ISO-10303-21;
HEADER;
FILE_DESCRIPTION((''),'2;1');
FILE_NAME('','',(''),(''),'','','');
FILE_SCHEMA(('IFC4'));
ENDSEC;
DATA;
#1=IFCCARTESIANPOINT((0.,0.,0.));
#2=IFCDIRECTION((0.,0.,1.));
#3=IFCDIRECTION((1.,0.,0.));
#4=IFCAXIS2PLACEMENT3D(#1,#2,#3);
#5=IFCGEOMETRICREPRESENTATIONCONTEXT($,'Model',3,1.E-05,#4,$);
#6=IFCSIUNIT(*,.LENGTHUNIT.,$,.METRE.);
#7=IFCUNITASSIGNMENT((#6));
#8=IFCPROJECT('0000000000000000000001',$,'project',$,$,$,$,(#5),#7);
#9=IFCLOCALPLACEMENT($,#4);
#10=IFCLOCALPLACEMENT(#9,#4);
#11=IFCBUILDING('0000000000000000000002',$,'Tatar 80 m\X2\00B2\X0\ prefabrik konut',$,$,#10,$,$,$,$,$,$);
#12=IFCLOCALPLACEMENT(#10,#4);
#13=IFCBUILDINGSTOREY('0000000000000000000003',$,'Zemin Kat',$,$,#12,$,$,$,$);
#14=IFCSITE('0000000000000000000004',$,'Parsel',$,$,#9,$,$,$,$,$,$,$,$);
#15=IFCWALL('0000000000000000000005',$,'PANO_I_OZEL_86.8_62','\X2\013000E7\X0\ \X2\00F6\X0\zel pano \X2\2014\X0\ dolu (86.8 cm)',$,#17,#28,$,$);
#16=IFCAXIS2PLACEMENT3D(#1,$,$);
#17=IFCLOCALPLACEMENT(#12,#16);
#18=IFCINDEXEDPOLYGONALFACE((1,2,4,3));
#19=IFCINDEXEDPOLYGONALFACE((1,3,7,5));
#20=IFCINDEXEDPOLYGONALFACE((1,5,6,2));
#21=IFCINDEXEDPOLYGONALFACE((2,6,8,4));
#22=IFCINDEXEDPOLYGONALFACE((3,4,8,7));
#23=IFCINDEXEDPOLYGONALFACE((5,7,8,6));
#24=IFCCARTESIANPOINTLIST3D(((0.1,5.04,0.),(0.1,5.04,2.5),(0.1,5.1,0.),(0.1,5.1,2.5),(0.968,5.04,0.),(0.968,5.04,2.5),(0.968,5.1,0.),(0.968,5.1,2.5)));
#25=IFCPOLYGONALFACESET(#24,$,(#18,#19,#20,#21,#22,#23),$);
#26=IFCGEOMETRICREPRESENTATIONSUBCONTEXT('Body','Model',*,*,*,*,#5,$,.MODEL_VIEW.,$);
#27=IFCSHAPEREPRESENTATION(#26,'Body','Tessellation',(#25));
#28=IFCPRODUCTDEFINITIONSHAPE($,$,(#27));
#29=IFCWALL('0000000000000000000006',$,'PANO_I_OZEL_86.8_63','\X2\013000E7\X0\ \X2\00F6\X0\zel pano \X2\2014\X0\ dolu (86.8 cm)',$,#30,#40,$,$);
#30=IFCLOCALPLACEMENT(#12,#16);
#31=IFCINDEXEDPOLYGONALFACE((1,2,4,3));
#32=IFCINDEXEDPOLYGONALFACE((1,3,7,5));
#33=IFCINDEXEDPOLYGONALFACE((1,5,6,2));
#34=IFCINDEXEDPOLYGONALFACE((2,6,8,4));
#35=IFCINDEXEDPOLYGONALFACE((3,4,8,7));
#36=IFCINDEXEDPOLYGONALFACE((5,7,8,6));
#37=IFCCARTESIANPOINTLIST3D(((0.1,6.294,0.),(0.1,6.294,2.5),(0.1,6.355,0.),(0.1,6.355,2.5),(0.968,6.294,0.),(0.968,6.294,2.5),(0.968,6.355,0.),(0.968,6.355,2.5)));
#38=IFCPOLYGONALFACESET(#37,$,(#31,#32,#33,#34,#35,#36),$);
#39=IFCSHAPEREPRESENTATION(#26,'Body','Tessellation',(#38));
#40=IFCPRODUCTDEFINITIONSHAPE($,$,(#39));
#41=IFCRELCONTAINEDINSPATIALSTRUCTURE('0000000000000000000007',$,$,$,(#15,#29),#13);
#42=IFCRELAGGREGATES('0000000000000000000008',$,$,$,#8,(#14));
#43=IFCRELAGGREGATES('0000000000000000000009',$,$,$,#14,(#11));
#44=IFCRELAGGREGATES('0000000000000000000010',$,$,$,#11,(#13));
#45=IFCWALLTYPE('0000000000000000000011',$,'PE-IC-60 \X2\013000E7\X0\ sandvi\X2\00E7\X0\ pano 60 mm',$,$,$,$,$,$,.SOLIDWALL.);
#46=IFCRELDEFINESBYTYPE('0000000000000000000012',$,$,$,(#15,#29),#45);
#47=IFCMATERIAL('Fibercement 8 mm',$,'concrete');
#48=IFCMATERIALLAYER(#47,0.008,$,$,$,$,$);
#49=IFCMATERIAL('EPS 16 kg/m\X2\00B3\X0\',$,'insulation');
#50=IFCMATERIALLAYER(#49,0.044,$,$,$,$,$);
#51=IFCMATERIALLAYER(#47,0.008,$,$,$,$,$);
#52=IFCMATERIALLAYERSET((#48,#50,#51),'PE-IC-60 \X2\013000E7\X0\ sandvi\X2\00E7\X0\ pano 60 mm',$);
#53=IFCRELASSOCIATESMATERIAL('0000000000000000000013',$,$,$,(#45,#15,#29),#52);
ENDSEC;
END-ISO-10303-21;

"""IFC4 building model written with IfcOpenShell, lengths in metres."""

from ifc_helpers import new_model, si_unit, frame, origin_with_axes, place, context, subcontext, project, spatial, line, indexed_curve, outline, extrude, material, layer, layer_set, layer_usage, type_object, element, save


model = new_model("IFC4")

# Units and contexts
model_context = context("Model", 3, precision=1e-05, world=origin_with_axes())
body_context = subcontext(model_context, "Body", "Model", "MODEL_VIEW")
ifc_project = project(units=[si_unit("LENGTHUNIT", "METRE")], contexts=[model_context])

# Site, building, storey
site_placement = place(None, origin_with_axes())
site = spatial("IfcSite", under=ifc_project, at=site_placement, Name="Parsel")
building_placement = place(site_placement, origin_with_axes())
building = spatial("IfcBuilding", under=site, at=building_placement, Name="Tatar 80 m² prefabrik konut")
storey_placement = place(building_placement, origin_with_axes())
storey = spatial("IfcBuildingStorey", under=building, at=storey_placement, Name="Zemin Kat")

# Shared definitions
ifc_material_1 = material(Name="Fibercement 8 mm", Category="concrete")
ifc_material_2 = material(Name="EPS 16 kg/m³", Category="insulation")

# Shared definitions
ifc_layer_1 = layer(ifc_material_1, 0.008)
ifc_layer_2 = layer(ifc_material_2, 0.044)
ifc_layer_3 = layer(ifc_material_1, 0.008)
ifc_layer_set_1 = layer_set([ifc_layer_1, ifc_layer_2, ifc_layer_3], Name="PE-IC-60 İç sandviç pano 60 mm")
wall_type_1 = type_object("IfcWallType", Name="PE-IC-60 İç sandviç pano 60 mm", PredefinedType="SOLIDWALL", material=ifc_layer_set_1)

# Walls
ifc_layer_usage_1 = layer_usage(ifc_layer_set_1, "AXIS2", "POSITIVE", 0.0)
wall_1_placement = place(storey_placement, frame((0.1, 5.04, 0.0), z_axis=(0.0, 0.0, 1.0), x_axis=(1.0, 0.0, 0.0)))
element("IfcWall", 1, at=wall_1_placement, inside=storey, type_object=wall_type_1, material=ifc_layer_usage_1, Name="PANO_I_OZEL_86.8_62", Description="İç özel pano — dolu (86.8 cm)", context=body_context, shape_type="SweptSolid", body=[
    extrude(outline(indexed_curve([(0.0, 0.0), (0.868, 0.0), (0.868, 0.06), (0.0, 0.06)], segments=[line(1, 2, 3, 4, 1)])), origin_with_axes(), (0.0, 0.0, 1.0), 2.5),
])
ifc_layer_usage_2 = layer_usage(ifc_layer_set_1, "AXIS2", "POSITIVE", 0.0)
wall_2_placement = place(storey_placement, frame((0.1, 6.294, 0.0), z_axis=(0.0, 0.0, 1.0), x_axis=(1.0, 0.0, 0.0)))
element("IfcWall", 2, at=wall_2_placement, inside=storey, type_object=wall_type_1, material=ifc_layer_usage_2, Name="PANO_I_OZEL_86.8_63", Description="İç özel pano — dolu (86.8 cm)", context=body_context, shape_type="SweptSolid", body=[
    extrude(outline(indexed_curve([(0.0, 0.0), (0.868, 0.0), (0.868, 0.061), (0.0, 0.061)], segments=[line(1, 2, 3, 4, 1)])), origin_with_axes(), (0.0, 0.0, 1.0), 2.5),
])

save(model, "model.ifc")
